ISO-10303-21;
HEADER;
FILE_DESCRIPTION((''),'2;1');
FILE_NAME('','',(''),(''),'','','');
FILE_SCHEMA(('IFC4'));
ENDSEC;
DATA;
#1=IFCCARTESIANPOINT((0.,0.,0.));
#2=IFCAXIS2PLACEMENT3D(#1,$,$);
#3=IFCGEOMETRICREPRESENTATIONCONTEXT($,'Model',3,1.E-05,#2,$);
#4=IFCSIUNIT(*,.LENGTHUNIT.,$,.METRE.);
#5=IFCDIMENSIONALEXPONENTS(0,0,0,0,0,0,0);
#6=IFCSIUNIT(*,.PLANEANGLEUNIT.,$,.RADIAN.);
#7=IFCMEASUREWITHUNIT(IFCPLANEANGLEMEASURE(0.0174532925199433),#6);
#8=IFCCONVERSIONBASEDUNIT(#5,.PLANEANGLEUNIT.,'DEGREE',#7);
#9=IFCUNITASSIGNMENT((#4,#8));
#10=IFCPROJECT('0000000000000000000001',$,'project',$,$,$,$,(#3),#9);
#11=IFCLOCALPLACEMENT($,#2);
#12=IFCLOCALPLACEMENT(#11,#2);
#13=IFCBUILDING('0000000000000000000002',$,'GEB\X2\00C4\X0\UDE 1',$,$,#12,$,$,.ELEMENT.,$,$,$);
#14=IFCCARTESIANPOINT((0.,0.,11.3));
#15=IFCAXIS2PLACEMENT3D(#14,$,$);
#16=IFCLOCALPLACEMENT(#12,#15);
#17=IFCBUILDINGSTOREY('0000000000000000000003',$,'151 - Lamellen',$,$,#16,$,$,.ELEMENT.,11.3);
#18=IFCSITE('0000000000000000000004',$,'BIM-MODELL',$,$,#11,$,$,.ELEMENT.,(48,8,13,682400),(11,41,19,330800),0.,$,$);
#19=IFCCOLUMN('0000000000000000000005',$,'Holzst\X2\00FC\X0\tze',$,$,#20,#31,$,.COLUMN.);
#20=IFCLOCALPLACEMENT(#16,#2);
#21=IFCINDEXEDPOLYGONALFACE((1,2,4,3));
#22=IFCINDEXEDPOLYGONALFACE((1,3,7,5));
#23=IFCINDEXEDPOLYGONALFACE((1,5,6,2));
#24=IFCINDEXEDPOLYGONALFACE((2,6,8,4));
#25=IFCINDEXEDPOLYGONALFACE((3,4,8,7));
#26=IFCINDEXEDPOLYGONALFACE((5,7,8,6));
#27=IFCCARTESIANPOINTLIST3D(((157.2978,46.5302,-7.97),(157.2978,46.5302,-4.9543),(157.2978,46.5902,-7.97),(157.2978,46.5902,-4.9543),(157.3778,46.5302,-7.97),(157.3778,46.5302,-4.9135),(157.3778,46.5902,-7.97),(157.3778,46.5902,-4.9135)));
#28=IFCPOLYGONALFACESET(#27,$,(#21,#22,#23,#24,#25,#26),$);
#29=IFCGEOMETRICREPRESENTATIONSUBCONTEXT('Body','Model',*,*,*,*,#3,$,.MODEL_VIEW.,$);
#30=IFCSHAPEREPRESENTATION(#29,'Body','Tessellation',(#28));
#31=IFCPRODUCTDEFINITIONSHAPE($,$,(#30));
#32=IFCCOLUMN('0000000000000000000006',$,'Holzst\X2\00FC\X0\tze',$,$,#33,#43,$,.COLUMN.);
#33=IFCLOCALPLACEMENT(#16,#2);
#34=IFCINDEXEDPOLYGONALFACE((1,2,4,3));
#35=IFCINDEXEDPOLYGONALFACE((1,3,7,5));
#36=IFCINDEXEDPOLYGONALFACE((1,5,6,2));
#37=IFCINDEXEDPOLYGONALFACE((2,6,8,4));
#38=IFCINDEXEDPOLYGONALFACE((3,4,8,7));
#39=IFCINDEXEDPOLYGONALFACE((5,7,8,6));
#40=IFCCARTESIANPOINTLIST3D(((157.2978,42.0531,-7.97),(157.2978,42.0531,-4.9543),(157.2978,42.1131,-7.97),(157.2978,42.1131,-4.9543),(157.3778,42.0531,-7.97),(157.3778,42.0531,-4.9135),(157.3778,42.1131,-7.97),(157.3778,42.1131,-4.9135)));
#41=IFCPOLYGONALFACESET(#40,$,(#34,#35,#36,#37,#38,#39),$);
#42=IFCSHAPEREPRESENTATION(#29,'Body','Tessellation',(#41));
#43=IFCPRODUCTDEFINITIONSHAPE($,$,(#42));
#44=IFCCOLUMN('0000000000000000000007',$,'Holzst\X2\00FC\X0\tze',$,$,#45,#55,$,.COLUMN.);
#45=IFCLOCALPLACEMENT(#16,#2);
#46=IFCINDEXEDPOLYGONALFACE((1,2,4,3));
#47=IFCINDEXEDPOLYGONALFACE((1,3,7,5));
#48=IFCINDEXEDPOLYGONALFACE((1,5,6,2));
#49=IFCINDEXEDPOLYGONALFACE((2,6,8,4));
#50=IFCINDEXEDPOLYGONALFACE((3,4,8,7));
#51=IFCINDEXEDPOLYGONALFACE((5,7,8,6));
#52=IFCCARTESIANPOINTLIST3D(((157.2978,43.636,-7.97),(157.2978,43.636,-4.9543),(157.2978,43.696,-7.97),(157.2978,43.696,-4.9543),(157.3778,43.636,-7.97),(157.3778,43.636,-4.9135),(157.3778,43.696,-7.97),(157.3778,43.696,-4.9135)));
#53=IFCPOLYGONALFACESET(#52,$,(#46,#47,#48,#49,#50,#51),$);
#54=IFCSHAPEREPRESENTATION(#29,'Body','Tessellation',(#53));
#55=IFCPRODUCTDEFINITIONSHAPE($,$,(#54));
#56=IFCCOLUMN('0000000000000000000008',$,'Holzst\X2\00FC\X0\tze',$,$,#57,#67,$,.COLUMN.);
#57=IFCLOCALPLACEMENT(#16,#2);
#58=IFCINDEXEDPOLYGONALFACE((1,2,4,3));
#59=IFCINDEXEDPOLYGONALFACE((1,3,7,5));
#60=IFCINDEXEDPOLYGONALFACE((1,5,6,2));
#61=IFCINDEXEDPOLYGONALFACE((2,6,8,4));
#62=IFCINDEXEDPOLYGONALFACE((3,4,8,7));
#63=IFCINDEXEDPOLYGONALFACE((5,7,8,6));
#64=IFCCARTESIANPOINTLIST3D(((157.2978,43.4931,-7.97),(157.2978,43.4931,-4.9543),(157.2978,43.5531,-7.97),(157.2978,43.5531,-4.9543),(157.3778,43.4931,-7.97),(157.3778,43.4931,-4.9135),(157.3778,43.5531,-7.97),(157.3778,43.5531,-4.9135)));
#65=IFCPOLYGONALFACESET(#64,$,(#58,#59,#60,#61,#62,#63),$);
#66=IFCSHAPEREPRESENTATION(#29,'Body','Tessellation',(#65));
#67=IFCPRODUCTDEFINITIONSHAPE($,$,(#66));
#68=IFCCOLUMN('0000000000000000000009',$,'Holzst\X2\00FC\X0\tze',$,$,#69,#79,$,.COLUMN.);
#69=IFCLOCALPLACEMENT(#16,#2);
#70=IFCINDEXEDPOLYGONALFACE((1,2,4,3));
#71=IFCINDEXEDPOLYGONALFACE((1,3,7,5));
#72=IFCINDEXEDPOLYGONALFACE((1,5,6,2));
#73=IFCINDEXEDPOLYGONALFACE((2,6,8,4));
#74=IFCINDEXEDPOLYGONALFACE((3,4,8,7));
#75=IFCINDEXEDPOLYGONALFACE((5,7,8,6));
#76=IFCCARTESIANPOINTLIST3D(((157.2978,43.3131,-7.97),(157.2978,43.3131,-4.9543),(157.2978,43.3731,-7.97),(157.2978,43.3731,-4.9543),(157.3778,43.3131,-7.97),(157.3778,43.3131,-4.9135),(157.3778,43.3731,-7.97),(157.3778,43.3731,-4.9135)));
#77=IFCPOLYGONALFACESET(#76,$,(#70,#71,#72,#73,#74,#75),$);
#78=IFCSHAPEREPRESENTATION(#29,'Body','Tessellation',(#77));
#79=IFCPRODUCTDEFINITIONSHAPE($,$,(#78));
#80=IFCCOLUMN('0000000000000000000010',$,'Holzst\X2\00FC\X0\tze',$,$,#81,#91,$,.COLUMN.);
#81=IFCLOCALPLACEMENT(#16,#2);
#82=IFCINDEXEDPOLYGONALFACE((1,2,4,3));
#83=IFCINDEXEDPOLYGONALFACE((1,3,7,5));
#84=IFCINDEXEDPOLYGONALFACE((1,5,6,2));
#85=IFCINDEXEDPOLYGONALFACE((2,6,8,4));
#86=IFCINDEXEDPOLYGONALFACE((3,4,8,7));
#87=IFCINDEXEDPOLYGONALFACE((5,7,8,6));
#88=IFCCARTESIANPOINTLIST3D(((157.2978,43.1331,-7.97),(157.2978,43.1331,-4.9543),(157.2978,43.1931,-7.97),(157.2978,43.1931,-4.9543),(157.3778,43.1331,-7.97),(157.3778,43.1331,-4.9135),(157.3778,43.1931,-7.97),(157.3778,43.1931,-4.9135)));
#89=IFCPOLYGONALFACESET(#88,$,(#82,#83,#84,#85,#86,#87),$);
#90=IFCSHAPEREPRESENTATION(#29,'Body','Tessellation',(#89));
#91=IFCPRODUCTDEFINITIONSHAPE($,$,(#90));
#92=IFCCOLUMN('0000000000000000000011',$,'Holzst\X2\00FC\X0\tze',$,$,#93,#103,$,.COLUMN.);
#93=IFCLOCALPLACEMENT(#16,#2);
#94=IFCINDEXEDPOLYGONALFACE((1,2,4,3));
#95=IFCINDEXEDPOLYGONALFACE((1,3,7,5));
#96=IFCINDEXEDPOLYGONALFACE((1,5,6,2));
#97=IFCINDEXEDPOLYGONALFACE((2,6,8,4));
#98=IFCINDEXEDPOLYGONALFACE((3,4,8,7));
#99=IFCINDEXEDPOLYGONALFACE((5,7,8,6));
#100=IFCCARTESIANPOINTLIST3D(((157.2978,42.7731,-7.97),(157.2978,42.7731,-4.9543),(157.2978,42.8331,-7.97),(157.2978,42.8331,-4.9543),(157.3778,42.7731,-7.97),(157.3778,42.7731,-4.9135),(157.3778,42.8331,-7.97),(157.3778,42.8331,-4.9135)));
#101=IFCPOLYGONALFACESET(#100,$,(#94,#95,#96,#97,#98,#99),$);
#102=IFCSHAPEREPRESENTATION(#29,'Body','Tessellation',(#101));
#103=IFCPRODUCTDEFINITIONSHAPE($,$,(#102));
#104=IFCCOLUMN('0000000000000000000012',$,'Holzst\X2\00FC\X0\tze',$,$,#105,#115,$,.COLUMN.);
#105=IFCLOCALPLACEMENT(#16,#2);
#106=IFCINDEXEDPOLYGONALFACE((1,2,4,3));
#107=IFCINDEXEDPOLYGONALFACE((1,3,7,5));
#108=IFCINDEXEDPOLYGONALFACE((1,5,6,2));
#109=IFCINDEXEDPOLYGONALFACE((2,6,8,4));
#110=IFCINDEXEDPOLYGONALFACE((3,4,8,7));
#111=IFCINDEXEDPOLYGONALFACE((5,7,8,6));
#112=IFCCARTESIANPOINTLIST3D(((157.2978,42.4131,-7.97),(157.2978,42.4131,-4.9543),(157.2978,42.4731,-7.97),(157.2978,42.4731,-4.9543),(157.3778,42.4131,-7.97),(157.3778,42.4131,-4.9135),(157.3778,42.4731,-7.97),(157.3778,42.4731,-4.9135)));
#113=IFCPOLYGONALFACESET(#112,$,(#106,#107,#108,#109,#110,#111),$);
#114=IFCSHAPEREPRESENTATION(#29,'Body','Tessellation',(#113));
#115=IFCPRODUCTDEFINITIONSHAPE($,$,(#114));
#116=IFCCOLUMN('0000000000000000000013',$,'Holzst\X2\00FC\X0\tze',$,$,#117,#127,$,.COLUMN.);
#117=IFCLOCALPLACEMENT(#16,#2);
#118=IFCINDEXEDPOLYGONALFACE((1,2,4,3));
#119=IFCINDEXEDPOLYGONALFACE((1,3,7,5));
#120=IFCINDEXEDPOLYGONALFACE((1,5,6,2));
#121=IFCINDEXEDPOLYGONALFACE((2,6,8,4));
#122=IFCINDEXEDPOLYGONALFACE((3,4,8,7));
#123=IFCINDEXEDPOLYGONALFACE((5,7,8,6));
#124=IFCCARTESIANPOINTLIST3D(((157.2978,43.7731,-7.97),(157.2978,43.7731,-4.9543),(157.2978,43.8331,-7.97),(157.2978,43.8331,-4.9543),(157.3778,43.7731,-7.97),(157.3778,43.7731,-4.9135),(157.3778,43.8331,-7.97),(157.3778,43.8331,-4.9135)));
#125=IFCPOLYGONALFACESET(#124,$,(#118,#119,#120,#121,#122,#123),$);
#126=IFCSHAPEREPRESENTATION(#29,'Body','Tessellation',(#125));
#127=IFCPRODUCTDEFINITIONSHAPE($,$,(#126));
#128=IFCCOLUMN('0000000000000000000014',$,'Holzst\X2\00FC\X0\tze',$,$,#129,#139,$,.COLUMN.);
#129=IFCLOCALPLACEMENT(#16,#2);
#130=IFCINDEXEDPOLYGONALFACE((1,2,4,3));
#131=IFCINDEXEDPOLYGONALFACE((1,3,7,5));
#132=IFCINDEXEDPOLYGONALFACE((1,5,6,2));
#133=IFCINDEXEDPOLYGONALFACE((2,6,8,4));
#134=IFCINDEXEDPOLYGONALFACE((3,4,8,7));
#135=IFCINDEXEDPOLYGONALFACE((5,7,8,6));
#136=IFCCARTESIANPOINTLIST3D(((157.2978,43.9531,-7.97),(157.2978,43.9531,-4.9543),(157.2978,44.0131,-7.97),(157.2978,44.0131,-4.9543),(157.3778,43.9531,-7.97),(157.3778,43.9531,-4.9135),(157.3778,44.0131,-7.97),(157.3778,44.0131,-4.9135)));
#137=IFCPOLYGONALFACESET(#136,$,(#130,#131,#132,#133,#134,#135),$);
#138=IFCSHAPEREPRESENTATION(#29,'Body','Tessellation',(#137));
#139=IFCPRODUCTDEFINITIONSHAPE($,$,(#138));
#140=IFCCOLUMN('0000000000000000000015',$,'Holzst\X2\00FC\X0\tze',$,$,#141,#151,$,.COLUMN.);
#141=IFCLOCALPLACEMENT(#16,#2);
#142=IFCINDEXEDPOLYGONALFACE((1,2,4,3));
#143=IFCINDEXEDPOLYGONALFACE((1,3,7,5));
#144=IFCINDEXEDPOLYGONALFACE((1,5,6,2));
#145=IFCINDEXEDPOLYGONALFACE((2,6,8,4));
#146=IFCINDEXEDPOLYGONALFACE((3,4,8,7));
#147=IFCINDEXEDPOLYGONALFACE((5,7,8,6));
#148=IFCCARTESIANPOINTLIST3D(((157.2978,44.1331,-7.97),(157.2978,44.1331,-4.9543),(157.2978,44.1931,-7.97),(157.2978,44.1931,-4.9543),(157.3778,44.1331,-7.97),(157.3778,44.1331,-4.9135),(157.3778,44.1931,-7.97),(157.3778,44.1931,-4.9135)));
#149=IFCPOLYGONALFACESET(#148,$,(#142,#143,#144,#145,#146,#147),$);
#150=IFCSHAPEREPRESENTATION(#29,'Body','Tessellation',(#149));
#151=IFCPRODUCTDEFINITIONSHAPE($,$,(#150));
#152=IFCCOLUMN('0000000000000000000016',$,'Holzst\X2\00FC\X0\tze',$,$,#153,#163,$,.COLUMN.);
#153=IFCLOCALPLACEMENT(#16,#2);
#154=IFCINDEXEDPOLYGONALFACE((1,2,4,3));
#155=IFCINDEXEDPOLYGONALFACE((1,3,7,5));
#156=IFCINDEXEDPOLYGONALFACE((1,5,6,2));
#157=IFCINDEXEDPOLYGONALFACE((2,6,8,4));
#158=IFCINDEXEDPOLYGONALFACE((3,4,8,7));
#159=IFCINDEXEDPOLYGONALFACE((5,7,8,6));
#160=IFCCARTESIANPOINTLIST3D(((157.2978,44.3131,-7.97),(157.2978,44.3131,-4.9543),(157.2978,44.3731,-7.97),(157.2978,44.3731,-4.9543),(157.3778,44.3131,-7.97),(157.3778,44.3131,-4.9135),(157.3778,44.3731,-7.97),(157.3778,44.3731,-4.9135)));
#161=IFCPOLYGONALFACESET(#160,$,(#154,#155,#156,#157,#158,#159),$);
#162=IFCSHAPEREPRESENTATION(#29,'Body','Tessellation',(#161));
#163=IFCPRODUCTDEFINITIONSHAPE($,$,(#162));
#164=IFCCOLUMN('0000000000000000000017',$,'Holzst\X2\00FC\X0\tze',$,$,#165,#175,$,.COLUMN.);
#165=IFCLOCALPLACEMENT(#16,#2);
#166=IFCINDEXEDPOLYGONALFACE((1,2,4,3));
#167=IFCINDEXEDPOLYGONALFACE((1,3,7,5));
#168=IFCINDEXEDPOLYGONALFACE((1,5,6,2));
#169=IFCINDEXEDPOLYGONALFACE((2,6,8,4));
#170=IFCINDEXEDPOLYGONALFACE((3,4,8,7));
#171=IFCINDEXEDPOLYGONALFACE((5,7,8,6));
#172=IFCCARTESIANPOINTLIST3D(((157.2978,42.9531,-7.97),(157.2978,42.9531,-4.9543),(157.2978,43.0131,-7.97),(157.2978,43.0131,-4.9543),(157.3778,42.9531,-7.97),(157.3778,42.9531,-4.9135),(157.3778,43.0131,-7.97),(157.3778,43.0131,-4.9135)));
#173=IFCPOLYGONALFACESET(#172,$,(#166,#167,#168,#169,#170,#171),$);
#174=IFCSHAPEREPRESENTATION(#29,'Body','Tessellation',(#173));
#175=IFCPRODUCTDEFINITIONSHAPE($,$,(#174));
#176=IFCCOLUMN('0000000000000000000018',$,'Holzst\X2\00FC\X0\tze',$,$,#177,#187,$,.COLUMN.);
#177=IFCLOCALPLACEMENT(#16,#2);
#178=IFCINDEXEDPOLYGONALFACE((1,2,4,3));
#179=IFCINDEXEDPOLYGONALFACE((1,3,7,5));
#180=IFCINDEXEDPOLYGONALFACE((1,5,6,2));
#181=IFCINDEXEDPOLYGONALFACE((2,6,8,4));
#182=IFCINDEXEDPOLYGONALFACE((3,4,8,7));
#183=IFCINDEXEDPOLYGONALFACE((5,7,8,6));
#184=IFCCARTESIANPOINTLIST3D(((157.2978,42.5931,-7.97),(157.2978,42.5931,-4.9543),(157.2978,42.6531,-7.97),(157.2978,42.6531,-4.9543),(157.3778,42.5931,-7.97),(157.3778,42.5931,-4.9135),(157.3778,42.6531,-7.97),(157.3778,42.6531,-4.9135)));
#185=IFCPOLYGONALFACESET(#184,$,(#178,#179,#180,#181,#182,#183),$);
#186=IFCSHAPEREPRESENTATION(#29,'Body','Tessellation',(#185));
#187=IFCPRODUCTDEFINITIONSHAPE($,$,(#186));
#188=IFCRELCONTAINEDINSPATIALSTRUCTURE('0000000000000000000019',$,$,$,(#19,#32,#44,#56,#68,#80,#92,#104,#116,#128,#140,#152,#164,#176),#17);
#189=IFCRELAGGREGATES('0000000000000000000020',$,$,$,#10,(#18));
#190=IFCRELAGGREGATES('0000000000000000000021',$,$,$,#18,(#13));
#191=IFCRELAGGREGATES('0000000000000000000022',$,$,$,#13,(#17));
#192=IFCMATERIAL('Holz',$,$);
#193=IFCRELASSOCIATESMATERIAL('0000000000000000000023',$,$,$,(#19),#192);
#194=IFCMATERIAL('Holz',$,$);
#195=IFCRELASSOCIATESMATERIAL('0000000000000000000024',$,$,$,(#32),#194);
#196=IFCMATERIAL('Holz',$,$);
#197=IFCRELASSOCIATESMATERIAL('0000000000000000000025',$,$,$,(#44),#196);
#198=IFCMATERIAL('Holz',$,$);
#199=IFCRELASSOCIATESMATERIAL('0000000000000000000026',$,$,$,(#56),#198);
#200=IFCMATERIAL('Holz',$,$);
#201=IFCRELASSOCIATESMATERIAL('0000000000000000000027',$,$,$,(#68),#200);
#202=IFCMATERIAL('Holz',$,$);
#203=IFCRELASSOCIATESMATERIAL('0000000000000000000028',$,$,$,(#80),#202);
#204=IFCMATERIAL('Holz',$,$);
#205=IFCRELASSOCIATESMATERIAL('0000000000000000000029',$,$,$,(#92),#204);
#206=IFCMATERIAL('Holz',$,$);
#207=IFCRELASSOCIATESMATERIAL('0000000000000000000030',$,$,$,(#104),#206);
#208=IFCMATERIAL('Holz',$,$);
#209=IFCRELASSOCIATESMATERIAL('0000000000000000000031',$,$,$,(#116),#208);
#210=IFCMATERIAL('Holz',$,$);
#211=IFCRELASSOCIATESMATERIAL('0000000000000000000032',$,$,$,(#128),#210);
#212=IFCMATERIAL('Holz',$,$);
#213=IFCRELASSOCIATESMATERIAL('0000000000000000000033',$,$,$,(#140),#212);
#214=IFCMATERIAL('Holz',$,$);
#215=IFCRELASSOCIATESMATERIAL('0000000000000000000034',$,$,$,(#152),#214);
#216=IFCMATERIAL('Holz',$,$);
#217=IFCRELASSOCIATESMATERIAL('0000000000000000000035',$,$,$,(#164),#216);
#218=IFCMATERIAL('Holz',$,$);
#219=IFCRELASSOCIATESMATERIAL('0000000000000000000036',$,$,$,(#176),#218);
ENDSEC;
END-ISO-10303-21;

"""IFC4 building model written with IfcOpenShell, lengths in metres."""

from ifc_helpers import new_model, entity, si_unit, converted_unit, frame, frame_2d, origin, origin_with_axes, place, context, subcontext, project, spatial, rectangle, extrude, clip, halfspace, material, element, save


model = new_model("IFC4")

# Units and contexts
model_context = context("Model", 3, precision=1e-05, world=origin())
body_context = subcontext(model_context, "Body", "Model", "MODEL_VIEW")
ifc_project = project(units=[si_unit("LENGTHUNIT", "METRE"), converted_unit("PLANEANGLEUNIT", "DEGREE", entity("IfcPlaneAngleMeasure", 0.0174532925199433), si_unit("PLANEANGLEUNIT", "RADIAN"), dimensions=[0, 0, 0, 0, 0, 0, 0])], contexts=[model_context])

# Site, building, storey
site_placement = place(None, origin())
site = spatial("IfcSite", under=ifc_project, at=site_placement, Name="BIM-MODELL", CompositionType="ELEMENT", RefLatitude=(48, 8, 13, 682400), RefLongitude=(11, 41, 19, 330800), RefElevation=0.0)
building_placement = place(site_placement, origin())
building = spatial("IfcBuilding", under=site, at=building_placement, Name="GEBÄUDE 1", CompositionType="ELEMENT")
storey_placement = place(building_placement, frame((0.0, 0.0, 11.3)))
storey = spatial("IfcBuildingStorey", under=building, at=storey_placement, Name="151 - Lamellen", CompositionType="ELEMENT", Elevation=11.3)

# Columns
ifc_material_1 = material(Name="Holz")
column_1_placement = place(storey_placement, frame((157.3778, 46.5302, -7.97)))
element("IfcColumn", 1, at=column_1_placement, inside=storey, material=ifc_material_1, Name="Holzstütze", PredefinedType="COLUMN", context=body_context, shape_type="Clipping", body=[
    clip(extrude(rectangle(XDim=0.06, YDim=0.08, at=frame_2d((-0.04, 0.03), x_axis=(0.0, 1.0))), origin_with_axes(), (0.0, 0.0, 1.0), 3.0565), halfspace(frame((-0.04, 0.03, 3.0361), z_axis=(0.45399, 0.0, -0.891007), x_axis=(-0.891007, 0.0, -0.45399)), True)),
])
ifc_material_2 = material(Name="Holz")
column_2_placement = place(storey_placement, frame((157.3778, 42.0531, -7.97)))
element("IfcColumn", 2, at=column_2_placement, inside=storey, material=ifc_material_2, Name="Holzstütze", PredefinedType="COLUMN", context=body_context, shape_type="Clipping", body=[
    clip(extrude(rectangle(XDim=0.06, YDim=0.08, at=frame_2d((-0.04, 0.03), x_axis=(0.0, 1.0))), origin_with_axes(), (0.0, 0.0, 1.0), 3.0565), halfspace(frame((-0.04, 0.03, 3.0361), z_axis=(0.45399, 0.0, -0.891007), x_axis=(-0.891007, 0.0, -0.45399)), True)),
])
ifc_material_3 = material(Name="Holz")
column_3_placement = place(storey_placement, frame((157.3778, 43.636, -7.97)))
element("IfcColumn", 3, at=column_3_placement, inside=storey, material=ifc_material_3, Name="Holzstütze", PredefinedType="COLUMN", context=body_context, shape_type="Clipping", body=[
    clip(extrude(rectangle(XDim=0.06, YDim=0.08, at=frame_2d((-0.04, 0.03), x_axis=(0.0, 1.0))), origin_with_axes(), (0.0, 0.0, 1.0), 3.0565), halfspace(frame((-0.04, 0.03, 3.0361), z_axis=(0.45399, 0.0, -0.891007), x_axis=(-0.891007, 0.0, -0.45399)), True)),
])
ifc_material_4 = material(Name="Holz")
column_4_placement = place(storey_placement, frame((157.3778, 43.4931, -7.97)))
element("IfcColumn", 4, at=column_4_placement, inside=storey, material=ifc_material_4, Name="Holzstütze", PredefinedType="COLUMN", context=body_context, shape_type="Clipping", body=[
    clip(extrude(rectangle(XDim=0.06, YDim=0.08, at=frame_2d((-0.04, 0.03), x_axis=(0.0, 1.0))), origin_with_axes(), (0.0, 0.0, 1.0), 3.0565), halfspace(frame((-0.04, 0.03, 3.0361), z_axis=(0.45399, 0.0, -0.891007), x_axis=(-0.891007, 0.0, -0.45399)), True)),
])
ifc_material_5 = material(Name="Holz")
column_5_placement = place(storey_placement, frame((157.3778, 43.3131, -7.97)))
element("IfcColumn", 5, at=column_5_placement, inside=storey, material=ifc_material_5, Name="Holzstütze", PredefinedType="COLUMN", context=body_context, shape_type="Clipping", body=[
    clip(extrude(rectangle(XDim=0.06, YDim=0.08, at=frame_2d((-0.04, 0.03), x_axis=(0.0, 1.0))), origin_with_axes(), (0.0, 0.0, 1.0), 3.0565), halfspace(frame((-0.04, 0.03, 3.0361), z_axis=(0.45399, 0.0, -0.891007), x_axis=(-0.891007, 0.0, -0.45399)), True)),
])
ifc_material_6 = material(Name="Holz")
column_6_placement = place(storey_placement, frame((157.3778, 43.1331, -7.97)))
element("IfcColumn", 6, at=column_6_placement, inside=storey, material=ifc_material_6, Name="Holzstütze", PredefinedType="COLUMN", context=body_context, shape_type="Clipping", body=[
    clip(extrude(rectangle(XDim=0.06, YDim=0.08, at=frame_2d((-0.04, 0.03), x_axis=(0.0, 1.0))), origin_with_axes(), (0.0, 0.0, 1.0), 3.0565), halfspace(frame((-0.04, 0.03, 3.0361), z_axis=(0.45399, 0.0, -0.891007), x_axis=(-0.891007, 0.0, -0.45399)), True)),
])
ifc_material_7 = material(Name="Holz")
column_7_placement = place(storey_placement, frame((157.3778, 42.7731, -7.97)))
element("IfcColumn", 7, at=column_7_placement, inside=storey, material=ifc_material_7, Name="Holzstütze", PredefinedType="COLUMN", context=body_context, shape_type="Clipping", body=[
    clip(extrude(rectangle(XDim=0.06, YDim=0.08, at=frame_2d((-0.04, 0.03), x_axis=(0.0, 1.0))), origin_with_axes(), (0.0, 0.0, 1.0), 3.0565), halfspace(frame((-0.04, 0.03, 3.0361), z_axis=(0.45399, 0.0, -0.891007), x_axis=(-0.891007, 0.0, -0.45399)), True)),
])
ifc_material_8 = material(Name="Holz")
column_8_placement = place(storey_placement, frame((157.3778, 42.4131, -7.97)))
element("IfcColumn", 8, at=column_8_placement, inside=storey, material=ifc_material_8, Name="Holzstütze", PredefinedType="COLUMN", context=body_context, shape_type="Clipping", body=[
    clip(extrude(rectangle(XDim=0.06, YDim=0.08, at=frame_2d((-0.04, 0.03), x_axis=(0.0, 1.0))), origin_with_axes(), (0.0, 0.0, 1.0), 3.0565), halfspace(frame((-0.04, 0.03, 3.0361), z_axis=(0.45399, 0.0, -0.891007), x_axis=(-0.891007, 0.0, -0.45399)), True)),
])
ifc_material_9 = material(Name="Holz")
column_9_placement = place(storey_placement, frame((157.3778, 43.7731, -7.97)))
element("IfcColumn", 9, at=column_9_placement, inside=storey, material=ifc_material_9, Name="Holzstütze", PredefinedType="COLUMN", context=body_context, shape_type="Clipping", body=[
    clip(extrude(rectangle(XDim=0.06, YDim=0.08, at=frame_2d((-0.04, 0.03), x_axis=(0.0, 1.0))), origin_with_axes(), (0.0, 0.0, 1.0), 3.0565), halfspace(frame((-0.04, 0.03, 3.0361), z_axis=(0.45399, 0.0, -0.891007), x_axis=(-0.891007, 0.0, -0.45399)), True)),
])
ifc_material_10 = material(Name="Holz")
column_10_placement = place(storey_placement, frame((157.3778, 43.9531, -7.97)))
element("IfcColumn", 10, at=column_10_placement, inside=storey, material=ifc_material_10, Name="Holzstütze", PredefinedType="COLUMN", context=body_context, shape_type="Clipping", body=[
    clip(extrude(rectangle(XDim=0.06, YDim=0.08, at=frame_2d((-0.04, 0.03), x_axis=(0.0, 1.0))), origin_with_axes(), (0.0, 0.0, 1.0), 3.0565), halfspace(frame((-0.04, 0.03, 3.0361), z_axis=(0.45399, 0.0, -0.891007), x_axis=(-0.891007, 0.0, -0.45399)), True)),
])
ifc_material_11 = material(Name="Holz")
column_11_placement = place(storey_placement, frame((157.3778, 44.1331, -7.97)))
element("IfcColumn", 11, at=column_11_placement, inside=storey, material=ifc_material_11, Name="Holzstütze", PredefinedType="COLUMN", context=body_context, shape_type="Clipping", body=[
    clip(extrude(rectangle(XDim=0.06, YDim=0.08, at=frame_2d((-0.04, 0.03), x_axis=(0.0, 1.0))), origin_with_axes(), (0.0, 0.0, 1.0), 3.0565), halfspace(frame((-0.04, 0.03, 3.0361), z_axis=(0.45399, 0.0, -0.891007), x_axis=(-0.891007, 0.0, -0.45399)), True)),
])
ifc_material_12 = material(Name="Holz")
column_12_placement = place(storey_placement, frame((157.3778, 44.3131, -7.97)))
element("IfcColumn", 12, at=column_12_placement, inside=storey, material=ifc_material_12, Name="Holzstütze", PredefinedType="COLUMN", context=body_context, shape_type="Clipping", body=[
    clip(extrude(rectangle(XDim=0.06, YDim=0.08, at=frame_2d((-0.04, 0.03), x_axis=(0.0, 1.0))), origin_with_axes(), (0.0, 0.0, 1.0), 3.0565), halfspace(frame((-0.04, 0.03, 3.0361), z_axis=(0.45399, 0.0, -0.891007), x_axis=(-0.891007, 0.0, -0.45399)), True)),
])
ifc_material_13 = material(Name="Holz")
column_13_placement = place(storey_placement, frame((157.3778, 42.9531, -7.97)))
element("IfcColumn", 13, at=column_13_placement, inside=storey, material=ifc_material_13, Name="Holzstütze", PredefinedType="COLUMN", context=body_context, shape_type="Clipping", body=[
    clip(extrude(rectangle(XDim=0.06, YDim=0.08, at=frame_2d((-0.04, 0.03), x_axis=(0.0, 1.0))), origin_with_axes(), (0.0, 0.0, 1.0), 3.0565), halfspace(frame((-0.04, 0.03, 3.0361), z_axis=(0.45399, 0.0, -0.891007), x_axis=(-0.891007, 0.0, -0.45399)), True)),
])
ifc_material_14 = material(Name="Holz")
column_14_placement = place(storey_placement, frame((157.3778, 42.5931, -7.97)))
element("IfcColumn", 14, at=column_14_placement, inside=storey, material=ifc_material_14, Name="Holzstütze", PredefinedType="COLUMN", context=body_context, shape_type="Clipping", body=[
    clip(extrude(rectangle(XDim=0.06, YDim=0.08, at=frame_2d((-0.04, 0.03), x_axis=(0.0, 1.0))), origin_with_axes(), (0.0, 0.0, 1.0), 3.0565), halfspace(frame((-0.04, 0.03, 3.0361), z_axis=(0.45399, 0.0, -0.891007), x_axis=(-0.891007, 0.0, -0.45399)), True)),
])

save(model, "model.ifc")
